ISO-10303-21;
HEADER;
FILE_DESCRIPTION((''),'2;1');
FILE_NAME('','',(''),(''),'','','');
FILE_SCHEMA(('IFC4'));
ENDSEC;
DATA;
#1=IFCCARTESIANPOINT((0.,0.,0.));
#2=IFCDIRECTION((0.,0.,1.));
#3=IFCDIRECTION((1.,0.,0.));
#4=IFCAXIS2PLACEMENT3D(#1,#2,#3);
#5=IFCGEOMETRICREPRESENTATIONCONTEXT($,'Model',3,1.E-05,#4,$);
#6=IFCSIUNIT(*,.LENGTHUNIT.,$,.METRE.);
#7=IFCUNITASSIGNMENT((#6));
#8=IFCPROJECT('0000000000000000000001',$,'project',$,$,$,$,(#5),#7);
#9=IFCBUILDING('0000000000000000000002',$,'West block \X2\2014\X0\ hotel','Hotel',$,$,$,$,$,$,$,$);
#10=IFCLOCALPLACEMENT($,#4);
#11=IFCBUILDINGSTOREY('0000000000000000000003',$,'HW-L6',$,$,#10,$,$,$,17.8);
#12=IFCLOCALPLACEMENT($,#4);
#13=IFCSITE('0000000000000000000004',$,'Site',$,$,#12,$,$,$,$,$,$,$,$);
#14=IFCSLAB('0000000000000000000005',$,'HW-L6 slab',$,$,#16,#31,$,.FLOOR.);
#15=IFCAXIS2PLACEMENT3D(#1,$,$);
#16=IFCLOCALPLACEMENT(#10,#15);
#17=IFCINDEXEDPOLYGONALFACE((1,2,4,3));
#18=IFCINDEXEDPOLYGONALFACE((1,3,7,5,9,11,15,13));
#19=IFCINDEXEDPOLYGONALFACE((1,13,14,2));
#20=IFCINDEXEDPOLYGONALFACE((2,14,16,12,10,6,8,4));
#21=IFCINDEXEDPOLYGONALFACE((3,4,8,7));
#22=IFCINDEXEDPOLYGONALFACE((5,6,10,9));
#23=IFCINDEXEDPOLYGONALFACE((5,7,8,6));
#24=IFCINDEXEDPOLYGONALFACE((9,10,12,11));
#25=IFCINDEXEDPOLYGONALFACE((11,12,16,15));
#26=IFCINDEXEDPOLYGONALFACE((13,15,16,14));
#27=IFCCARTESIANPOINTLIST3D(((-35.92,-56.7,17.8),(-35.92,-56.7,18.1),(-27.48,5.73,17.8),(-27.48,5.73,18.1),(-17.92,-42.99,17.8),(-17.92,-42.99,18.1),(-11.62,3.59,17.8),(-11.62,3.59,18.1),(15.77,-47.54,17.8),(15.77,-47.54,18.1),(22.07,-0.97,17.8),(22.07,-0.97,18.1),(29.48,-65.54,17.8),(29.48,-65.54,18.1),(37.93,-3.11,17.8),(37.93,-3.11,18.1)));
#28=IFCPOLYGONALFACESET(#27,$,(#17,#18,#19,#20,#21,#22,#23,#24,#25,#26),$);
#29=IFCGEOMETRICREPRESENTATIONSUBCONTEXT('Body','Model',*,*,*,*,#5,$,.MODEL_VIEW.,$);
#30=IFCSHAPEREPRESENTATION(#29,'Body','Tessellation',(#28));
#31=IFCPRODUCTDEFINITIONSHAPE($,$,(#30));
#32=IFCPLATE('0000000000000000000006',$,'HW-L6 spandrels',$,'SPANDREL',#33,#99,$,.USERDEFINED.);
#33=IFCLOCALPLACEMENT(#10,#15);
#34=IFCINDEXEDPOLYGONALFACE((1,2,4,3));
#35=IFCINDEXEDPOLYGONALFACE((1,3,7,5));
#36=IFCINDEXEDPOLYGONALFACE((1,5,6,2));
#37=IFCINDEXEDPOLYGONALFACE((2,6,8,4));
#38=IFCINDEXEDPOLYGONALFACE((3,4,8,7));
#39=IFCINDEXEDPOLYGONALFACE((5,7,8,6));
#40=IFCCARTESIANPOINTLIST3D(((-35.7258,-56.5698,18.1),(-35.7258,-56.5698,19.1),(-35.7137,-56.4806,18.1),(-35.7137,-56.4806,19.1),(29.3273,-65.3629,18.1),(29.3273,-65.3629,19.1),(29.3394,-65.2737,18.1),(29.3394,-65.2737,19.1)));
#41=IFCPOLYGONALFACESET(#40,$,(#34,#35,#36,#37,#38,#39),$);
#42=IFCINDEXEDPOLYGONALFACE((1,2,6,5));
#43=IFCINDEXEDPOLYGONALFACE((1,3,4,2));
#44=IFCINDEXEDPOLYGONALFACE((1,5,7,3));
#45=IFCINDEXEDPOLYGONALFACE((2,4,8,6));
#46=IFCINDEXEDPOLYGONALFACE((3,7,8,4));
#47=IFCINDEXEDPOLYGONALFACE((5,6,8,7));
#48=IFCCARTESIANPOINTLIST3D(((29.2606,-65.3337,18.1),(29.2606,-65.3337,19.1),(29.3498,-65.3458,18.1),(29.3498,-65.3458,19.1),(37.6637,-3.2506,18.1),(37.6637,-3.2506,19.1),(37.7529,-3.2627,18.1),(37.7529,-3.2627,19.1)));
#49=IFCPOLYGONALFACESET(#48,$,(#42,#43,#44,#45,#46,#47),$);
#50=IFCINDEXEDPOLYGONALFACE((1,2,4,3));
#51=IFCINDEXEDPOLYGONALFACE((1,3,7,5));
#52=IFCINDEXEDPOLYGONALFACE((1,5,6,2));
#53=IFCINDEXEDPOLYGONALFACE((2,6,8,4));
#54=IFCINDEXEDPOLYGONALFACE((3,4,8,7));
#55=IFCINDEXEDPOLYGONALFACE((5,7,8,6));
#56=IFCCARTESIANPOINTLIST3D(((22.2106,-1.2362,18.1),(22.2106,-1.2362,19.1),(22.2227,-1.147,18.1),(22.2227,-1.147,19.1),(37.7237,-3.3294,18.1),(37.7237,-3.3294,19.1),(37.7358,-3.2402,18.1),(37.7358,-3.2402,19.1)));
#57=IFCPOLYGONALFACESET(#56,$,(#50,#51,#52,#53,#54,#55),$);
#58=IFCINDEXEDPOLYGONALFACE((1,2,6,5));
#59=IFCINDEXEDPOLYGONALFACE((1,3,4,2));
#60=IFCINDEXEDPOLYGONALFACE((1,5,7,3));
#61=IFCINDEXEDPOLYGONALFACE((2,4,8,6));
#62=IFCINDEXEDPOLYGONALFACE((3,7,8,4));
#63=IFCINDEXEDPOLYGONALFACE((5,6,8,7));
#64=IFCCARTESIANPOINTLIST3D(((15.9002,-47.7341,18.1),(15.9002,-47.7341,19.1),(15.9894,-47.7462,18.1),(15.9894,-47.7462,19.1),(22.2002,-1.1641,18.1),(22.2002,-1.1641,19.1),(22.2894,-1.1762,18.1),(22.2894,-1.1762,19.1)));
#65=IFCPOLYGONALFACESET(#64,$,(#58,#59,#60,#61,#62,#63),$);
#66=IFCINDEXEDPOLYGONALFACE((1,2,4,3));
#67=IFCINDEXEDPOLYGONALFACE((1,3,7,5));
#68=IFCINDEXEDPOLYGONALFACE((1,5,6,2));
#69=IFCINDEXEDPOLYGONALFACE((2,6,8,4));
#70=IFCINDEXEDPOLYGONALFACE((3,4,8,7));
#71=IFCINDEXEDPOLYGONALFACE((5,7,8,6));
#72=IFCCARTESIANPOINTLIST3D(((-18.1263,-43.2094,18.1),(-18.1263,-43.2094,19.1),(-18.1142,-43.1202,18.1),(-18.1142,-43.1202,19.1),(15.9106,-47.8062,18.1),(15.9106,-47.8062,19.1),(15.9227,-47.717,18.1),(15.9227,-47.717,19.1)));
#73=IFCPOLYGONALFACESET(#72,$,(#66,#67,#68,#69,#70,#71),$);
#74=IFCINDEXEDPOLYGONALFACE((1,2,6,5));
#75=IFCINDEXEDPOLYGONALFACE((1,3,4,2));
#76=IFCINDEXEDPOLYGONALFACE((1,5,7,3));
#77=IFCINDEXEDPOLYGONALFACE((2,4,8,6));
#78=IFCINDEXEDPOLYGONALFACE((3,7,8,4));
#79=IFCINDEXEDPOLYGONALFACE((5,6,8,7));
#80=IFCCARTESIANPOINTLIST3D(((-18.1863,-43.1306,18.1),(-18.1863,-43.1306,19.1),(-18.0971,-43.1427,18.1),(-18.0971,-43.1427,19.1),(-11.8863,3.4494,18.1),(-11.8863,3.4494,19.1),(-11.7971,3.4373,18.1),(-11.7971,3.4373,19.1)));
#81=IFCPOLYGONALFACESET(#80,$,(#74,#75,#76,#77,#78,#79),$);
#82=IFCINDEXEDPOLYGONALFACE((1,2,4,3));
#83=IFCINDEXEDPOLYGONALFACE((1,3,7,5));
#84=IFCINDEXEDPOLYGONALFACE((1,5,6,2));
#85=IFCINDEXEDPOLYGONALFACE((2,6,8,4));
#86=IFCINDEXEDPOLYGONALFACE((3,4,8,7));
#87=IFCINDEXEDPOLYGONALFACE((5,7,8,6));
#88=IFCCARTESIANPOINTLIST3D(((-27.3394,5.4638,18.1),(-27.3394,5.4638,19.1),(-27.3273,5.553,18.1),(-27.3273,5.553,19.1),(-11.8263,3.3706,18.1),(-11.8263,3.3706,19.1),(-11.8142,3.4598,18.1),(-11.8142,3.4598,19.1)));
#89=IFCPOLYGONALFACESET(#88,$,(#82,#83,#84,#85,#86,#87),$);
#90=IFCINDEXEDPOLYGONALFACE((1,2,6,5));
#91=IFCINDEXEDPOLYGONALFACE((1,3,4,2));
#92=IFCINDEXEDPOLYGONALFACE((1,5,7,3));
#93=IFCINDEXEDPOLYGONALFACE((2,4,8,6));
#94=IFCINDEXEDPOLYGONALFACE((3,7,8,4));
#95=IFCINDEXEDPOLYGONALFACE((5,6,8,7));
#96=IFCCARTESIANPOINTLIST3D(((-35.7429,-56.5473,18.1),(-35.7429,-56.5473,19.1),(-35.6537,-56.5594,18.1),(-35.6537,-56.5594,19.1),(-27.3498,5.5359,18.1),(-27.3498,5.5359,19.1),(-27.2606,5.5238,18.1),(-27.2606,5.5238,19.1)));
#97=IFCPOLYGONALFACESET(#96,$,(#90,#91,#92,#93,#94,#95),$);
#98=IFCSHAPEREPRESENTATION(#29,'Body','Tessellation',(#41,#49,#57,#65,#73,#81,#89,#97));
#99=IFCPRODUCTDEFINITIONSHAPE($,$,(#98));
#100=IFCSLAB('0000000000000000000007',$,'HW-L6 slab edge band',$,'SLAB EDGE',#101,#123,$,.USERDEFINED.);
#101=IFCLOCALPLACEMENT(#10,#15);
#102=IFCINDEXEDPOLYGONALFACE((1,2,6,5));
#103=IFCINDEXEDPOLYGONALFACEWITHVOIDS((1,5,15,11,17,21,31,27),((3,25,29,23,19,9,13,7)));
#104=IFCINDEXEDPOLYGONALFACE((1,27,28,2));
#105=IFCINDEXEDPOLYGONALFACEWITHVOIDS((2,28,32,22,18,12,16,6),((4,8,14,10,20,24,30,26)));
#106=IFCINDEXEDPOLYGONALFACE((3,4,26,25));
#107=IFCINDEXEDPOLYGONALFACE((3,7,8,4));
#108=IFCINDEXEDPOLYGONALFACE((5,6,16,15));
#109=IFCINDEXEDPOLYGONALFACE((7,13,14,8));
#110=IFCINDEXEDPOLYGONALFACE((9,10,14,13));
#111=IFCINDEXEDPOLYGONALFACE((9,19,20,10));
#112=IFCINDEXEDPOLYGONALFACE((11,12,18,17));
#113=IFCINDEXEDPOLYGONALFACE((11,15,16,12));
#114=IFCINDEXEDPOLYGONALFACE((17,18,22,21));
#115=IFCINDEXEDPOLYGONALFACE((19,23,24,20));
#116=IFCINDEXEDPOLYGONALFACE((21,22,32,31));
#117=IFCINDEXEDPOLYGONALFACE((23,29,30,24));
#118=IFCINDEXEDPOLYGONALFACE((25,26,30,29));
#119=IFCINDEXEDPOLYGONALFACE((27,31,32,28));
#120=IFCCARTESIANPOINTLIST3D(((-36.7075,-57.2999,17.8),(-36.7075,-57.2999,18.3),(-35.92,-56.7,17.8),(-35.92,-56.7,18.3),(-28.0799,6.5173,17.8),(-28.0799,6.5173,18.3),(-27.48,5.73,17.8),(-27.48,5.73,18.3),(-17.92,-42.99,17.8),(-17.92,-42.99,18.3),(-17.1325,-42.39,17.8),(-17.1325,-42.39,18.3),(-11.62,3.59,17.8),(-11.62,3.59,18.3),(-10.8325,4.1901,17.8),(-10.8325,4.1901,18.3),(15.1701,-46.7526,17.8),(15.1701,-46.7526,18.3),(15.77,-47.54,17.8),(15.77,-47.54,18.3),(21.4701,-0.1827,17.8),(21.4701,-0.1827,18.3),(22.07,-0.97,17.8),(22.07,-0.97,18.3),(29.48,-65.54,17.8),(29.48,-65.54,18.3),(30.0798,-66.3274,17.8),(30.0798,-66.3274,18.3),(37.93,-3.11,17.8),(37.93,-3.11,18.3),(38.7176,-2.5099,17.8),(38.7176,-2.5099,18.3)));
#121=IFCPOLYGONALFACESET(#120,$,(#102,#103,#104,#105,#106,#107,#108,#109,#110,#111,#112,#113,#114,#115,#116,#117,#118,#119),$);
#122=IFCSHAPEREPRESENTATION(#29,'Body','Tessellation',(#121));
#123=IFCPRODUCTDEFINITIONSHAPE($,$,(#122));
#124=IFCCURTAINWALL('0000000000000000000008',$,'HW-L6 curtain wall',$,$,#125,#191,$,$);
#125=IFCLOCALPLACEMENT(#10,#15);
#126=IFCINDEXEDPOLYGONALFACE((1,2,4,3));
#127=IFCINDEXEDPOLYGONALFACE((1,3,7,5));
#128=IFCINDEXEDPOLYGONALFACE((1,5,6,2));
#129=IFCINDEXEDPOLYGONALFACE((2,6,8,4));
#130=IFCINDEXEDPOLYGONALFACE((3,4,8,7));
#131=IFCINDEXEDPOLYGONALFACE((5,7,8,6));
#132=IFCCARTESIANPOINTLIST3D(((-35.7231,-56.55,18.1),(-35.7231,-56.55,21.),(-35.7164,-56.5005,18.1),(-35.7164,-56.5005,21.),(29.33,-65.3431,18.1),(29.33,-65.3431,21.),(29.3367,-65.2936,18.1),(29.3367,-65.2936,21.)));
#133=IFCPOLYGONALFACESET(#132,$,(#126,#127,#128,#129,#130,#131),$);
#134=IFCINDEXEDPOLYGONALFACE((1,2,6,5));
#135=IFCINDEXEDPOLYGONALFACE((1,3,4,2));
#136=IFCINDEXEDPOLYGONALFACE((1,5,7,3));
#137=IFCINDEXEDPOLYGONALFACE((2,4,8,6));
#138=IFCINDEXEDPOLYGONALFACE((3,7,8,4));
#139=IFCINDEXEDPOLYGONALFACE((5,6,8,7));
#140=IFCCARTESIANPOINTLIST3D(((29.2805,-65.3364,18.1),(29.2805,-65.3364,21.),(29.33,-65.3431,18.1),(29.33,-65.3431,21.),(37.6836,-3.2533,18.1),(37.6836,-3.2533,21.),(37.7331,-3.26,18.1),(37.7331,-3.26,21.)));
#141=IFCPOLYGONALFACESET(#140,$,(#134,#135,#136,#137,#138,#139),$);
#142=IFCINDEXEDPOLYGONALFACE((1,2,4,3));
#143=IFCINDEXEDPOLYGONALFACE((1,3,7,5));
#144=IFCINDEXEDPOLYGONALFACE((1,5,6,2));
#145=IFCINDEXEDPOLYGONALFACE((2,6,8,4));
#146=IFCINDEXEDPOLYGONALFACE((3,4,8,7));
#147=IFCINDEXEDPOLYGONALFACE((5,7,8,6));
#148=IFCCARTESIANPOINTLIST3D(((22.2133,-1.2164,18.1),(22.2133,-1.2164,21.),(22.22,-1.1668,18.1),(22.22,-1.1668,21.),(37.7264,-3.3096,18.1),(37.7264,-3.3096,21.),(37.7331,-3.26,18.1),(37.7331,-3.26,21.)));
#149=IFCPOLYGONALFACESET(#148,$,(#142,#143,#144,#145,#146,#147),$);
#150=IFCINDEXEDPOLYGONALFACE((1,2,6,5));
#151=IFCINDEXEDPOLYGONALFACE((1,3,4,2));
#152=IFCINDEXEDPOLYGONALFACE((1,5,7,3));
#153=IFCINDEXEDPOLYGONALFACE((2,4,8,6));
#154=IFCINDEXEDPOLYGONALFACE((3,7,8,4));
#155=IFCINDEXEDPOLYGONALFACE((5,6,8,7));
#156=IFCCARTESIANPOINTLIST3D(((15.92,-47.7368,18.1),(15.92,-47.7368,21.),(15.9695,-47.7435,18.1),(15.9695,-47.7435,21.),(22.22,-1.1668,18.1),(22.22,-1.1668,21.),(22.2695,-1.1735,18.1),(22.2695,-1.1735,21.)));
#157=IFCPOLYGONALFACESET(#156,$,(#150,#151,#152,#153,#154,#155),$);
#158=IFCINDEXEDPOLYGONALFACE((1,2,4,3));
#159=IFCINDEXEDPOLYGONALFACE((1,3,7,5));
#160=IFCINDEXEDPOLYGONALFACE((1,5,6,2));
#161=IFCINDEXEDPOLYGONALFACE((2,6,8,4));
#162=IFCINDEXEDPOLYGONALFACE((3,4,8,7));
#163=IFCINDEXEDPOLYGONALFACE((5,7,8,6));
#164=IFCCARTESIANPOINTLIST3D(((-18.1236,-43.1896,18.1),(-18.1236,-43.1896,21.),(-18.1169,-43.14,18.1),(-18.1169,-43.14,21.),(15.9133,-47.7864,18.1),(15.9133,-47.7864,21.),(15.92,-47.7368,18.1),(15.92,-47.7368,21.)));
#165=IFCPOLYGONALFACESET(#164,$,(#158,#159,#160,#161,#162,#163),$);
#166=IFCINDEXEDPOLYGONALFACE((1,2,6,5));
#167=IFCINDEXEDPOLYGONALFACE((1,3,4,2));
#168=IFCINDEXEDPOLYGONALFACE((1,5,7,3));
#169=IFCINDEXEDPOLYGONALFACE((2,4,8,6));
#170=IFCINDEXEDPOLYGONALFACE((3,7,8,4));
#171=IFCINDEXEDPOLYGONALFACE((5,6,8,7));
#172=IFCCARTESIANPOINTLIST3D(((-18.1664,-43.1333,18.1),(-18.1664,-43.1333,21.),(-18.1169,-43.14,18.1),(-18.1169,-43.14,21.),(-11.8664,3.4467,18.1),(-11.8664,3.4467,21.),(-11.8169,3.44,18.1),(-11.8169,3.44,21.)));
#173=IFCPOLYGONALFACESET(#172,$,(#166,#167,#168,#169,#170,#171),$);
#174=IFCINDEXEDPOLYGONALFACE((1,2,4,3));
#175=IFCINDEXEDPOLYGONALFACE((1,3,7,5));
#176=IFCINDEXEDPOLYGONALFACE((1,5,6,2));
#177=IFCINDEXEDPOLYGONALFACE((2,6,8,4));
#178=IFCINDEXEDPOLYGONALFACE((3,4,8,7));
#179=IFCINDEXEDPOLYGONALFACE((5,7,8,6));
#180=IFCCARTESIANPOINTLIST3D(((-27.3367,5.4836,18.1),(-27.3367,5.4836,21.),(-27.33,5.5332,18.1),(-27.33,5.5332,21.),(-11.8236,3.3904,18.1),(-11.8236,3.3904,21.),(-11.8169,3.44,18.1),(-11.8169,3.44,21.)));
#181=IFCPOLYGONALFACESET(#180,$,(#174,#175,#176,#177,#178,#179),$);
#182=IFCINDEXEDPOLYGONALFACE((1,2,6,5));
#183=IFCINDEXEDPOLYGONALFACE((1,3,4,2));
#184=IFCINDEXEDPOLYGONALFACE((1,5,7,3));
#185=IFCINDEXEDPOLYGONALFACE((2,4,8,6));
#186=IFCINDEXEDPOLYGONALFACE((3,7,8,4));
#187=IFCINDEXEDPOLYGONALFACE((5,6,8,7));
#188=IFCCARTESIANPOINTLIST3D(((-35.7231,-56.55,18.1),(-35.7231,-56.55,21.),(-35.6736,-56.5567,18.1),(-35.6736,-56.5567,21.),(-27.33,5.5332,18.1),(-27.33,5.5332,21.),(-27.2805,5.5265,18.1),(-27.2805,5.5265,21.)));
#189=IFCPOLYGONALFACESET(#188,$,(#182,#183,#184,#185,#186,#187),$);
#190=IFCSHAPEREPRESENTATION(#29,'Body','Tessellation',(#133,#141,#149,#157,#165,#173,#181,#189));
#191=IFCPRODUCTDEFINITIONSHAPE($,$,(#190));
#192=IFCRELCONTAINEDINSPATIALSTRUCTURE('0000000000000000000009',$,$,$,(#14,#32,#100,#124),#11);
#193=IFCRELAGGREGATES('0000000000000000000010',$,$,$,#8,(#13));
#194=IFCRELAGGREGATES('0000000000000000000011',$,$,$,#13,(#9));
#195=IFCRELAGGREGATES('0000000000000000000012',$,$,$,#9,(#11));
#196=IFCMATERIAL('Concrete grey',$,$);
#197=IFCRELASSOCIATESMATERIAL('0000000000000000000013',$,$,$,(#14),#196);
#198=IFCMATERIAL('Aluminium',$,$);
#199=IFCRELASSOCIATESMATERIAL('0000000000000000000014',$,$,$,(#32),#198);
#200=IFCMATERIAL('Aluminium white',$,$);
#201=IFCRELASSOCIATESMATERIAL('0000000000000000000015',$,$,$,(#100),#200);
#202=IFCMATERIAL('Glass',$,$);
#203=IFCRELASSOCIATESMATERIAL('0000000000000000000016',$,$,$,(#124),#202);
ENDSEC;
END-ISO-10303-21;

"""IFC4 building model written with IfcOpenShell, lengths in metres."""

from ifc_helpers import new_model, si_unit, frame, origin_with_axes, place, context, subcontext, project, spatial, polyline, outline, extrude, material, element, save


model = new_model("IFC4")

# Units and contexts
model_context = context("Model", 3, precision=1e-05, world=origin_with_axes())
body_context = subcontext(model_context, "Body", "Model", "MODEL_VIEW")
ifc_project = project(units=[si_unit("LENGTHUNIT", "METRE")], contexts=[model_context])

# Site, building, storey
site_placement = place(None, origin_with_axes())
site = spatial("IfcSite", under=ifc_project, at=site_placement, Name="Site")
building = spatial("IfcBuilding", under=site, Name="West block — hotel", Description="Hotel")
storey_placement = place(None, origin_with_axes())
storey = spatial("IfcBuildingStorey", under=building, at=storey_placement, Name="HW-L6", Elevation=17.8)

# Shared definitions
ifc_material_1 = material(Name="Aluminium")

# Slab
ifc_material_2 = material(Name="Concrete grey")
slab_1_placement = place(storey_placement, origin_with_axes())
element("IfcSlab", 1, at=slab_1_placement, inside=storey, material=ifc_material_2, Name="HW-L6 slab", PredefinedType="FLOOR", context=body_context, shape_type="SweptSolid", body=[
    extrude(outline(polyline([(-35.92, -56.7), (29.48, -65.54), (37.93, -3.11), (22.07, -0.97), (15.77, -47.54), (-17.92, -42.99), (-11.62, 3.59), (-27.48, 5.73), (-35.92, -56.7)])), frame((0.0, 0.0, 17.8), z_axis=(0.0, 0.0, 1.0), x_axis=(1.0, 0.0, 0.0)), (0.0, 0.0, 1.0), 0.3),
])

# Plate
plate_placement = place(storey_placement, origin_with_axes())
element("IfcPlate", 2, at=plate_placement, inside=storey, material=ifc_material_1, Name="HW-L6 spandrels", ObjectType="SPANDREL", PredefinedType="USERDEFINED", context=body_context, shape_type="SweptSolid", body=[
    extrude(outline(polyline([(-35.7258, -56.5698), (29.3273, -65.3629), (29.3394, -65.2737), (-35.7137, -56.4806), (-35.7258, -56.5698)])), frame((0.0, 0.0, 18.1), z_axis=(0.0, 0.0, 1.0), x_axis=(1.0, 0.0, 0.0)), (0.0, 0.0, 1.0), 1.0),
    extrude(outline(polyline([(29.3498, -65.3458), (37.7529, -3.2627), (37.6637, -3.2506), (29.2606, -65.3337), (29.3498, -65.3458)])), frame((0.0, 0.0, 18.1), z_axis=(0.0, 0.0, 1.0), x_axis=(1.0, 0.0, 0.0)), (0.0, 0.0, 1.0), 1.0),
    extrude(outline(polyline([(37.7358, -3.2402), (22.2227, -1.147), (22.2106, -1.2362), (37.7237, -3.3294), (37.7358, -3.2402)])), frame((0.0, 0.0, 18.1), z_axis=(0.0, 0.0, 1.0), x_axis=(1.0, 0.0, 0.0)), (0.0, 0.0, 1.0), 1.0),
    extrude(outline(polyline([(22.2002, -1.1641), (15.9002, -47.7341), (15.9894, -47.7462), (22.2894, -1.1762), (22.2002, -1.1641)])), frame((0.0, 0.0, 18.1), z_axis=(0.0, 0.0, 1.0), x_axis=(1.0, 0.0, 0.0)), (0.0, 0.0, 1.0), 1.0),
    extrude(outline(polyline([(15.9227, -47.717), (-18.1142, -43.1202), (-18.1263, -43.2094), (15.9106, -47.8062), (15.9227, -47.717)])), frame((0.0, 0.0, 18.1), z_axis=(0.0, 0.0, 1.0), x_axis=(1.0, 0.0, 0.0)), (0.0, 0.0, 1.0), 1.0),
    extrude(outline(polyline([(-18.0971, -43.1427), (-11.7971, 3.4373), (-11.8863, 3.4494), (-18.1863, -43.1306), (-18.0971, -43.1427)])), frame((0.0, 0.0, 18.1), z_axis=(0.0, 0.0, 1.0), x_axis=(1.0, 0.0, 0.0)), (0.0, 0.0, 1.0), 1.0),
    extrude(outline(polyline([(-11.8142, 3.4598), (-27.3273, 5.553), (-27.3394, 5.4638), (-11.8263, 3.3706), (-11.8142, 3.4598)])), frame((0.0, 0.0, 18.1), z_axis=(0.0, 0.0, 1.0), x_axis=(1.0, 0.0, 0.0)), (0.0, 0.0, 1.0), 1.0),
    extrude(outline(polyline([(-27.3498, 5.5359), (-35.7429, -56.5473), (-35.6537, -56.5594), (-27.2606, 5.5238), (-27.3498, 5.5359)])), frame((0.0, 0.0, 18.1), z_axis=(0.0, 0.0, 1.0), x_axis=(1.0, 0.0, 0.0)), (0.0, 0.0, 1.0), 1.0),
])

# Slab
ifc_material_3 = material(Name="Aluminium white")
slab_2_placement = place(storey_placement, origin_with_axes())
element("IfcSlab", 3, at=slab_2_placement, inside=storey, material=ifc_material_3, Name="HW-L6 slab edge band", ObjectType="SLAB EDGE", PredefinedType="USERDEFINED", context=body_context, shape_type="SweptSolid", body=[
    extrude(outline(polyline([(-36.7075, -57.2999), (30.0798, -66.3274), (38.7176, -2.5099), (21.4701, -0.1827), (15.1701, -46.7526), (-17.1325, -42.39), (-10.8325, 4.1901), (-28.0799, 6.5173), (-36.7075, -57.2999)]), holes=[polyline([(-35.92, -56.7), (29.48, -65.54), (37.93, -3.11), (22.07, -0.97), (15.77, -47.54), (-17.92, -42.99), (-11.62, 3.59), (-27.48, 5.73), (-35.92, -56.7)])]), frame((0.0, 0.0, 17.8), z_axis=(0.0, 0.0, 1.0), x_axis=(1.0, 0.0, 0.0)), (0.0, 0.0, 1.0), 0.5),
])

# Curtain wall
ifc_material_4 = material(Name="Glass")
curtain_wall_placement = place(storey_placement, origin_with_axes())
element("IfcCurtainWall", 4, at=curtain_wall_placement, inside=storey, material=ifc_material_4, Name="HW-L6 curtain wall", context=body_context, shape_type="SweptSolid", body=[
    extrude(outline(polyline([(-35.7231, -56.55), (29.33, -65.3431), (29.3367, -65.2936), (-35.7164, -56.5005), (-35.7231, -56.55)])), frame((0.0, 0.0, 18.1), z_axis=(0.0, 0.0, 1.0), x_axis=(1.0, 0.0, 0.0)), (0.0, 0.0, 1.0), 2.9),
    extrude(outline(polyline([(29.33, -65.3431), (37.7331, -3.26), (37.6836, -3.2533), (29.2805, -65.3364), (29.33, -65.3431)])), frame((0.0, 0.0, 18.1), z_axis=(0.0, 0.0, 1.0), x_axis=(1.0, 0.0, 0.0)), (0.0, 0.0, 1.0), 2.9),
    extrude(outline(polyline([(37.7331, -3.26), (22.22, -1.1668), (22.2133, -1.2164), (37.7264, -3.3096), (37.7331, -3.26)])), frame((0.0, 0.0, 18.1), z_axis=(0.0, 0.0, 1.0), x_axis=(1.0, 0.0, 0.0)), (0.0, 0.0, 1.0), 2.9),
    extrude(outline(polyline([(22.22, -1.1668), (15.92, -47.7368), (15.9695, -47.7435), (22.2695, -1.1735), (22.22, -1.1668)])), frame((0.0, 0.0, 18.1), z_axis=(0.0, 0.0, 1.0), x_axis=(1.0, 0.0, 0.0)), (0.0, 0.0, 1.0), 2.9),
    extrude(outline(polyline([(15.92, -47.7368), (-18.1169, -43.14), (-18.1236, -43.1896), (15.9133, -47.7864), (15.92, -47.7368)])), frame((0.0, 0.0, 18.1), z_axis=(0.0, 0.0, 1.0), x_axis=(1.0, 0.0, 0.0)), (0.0, 0.0, 1.0), 2.9),
    extrude(outline(polyline([(-18.1169, -43.14), (-11.8169, 3.44), (-11.8664, 3.4467), (-18.1664, -43.1333), (-18.1169, -43.14)])), frame((0.0, 0.0, 18.1), z_axis=(0.0, 0.0, 1.0), x_axis=(1.0, 0.0, 0.0)), (0.0, 0.0, 1.0), 2.9),
    extrude(outline(polyline([(-11.8169, 3.44), (-27.33, 5.5332), (-27.3367, 5.4836), (-11.8236, 3.3904), (-11.8169, 3.44)])), frame((0.0, 0.0, 18.1), z_axis=(0.0, 0.0, 1.0), x_axis=(1.0, 0.0, 0.0)), (0.0, 0.0, 1.0), 2.9),
    extrude(outline(polyline([(-27.33, 5.5332), (-35.7231, -56.55), (-35.6736, -56.5567), (-27.2805, 5.5265), (-27.33, 5.5332)])), frame((0.0, 0.0, 18.1), z_axis=(0.0, 0.0, 1.0), x_axis=(1.0, 0.0, 0.0)), (0.0, 0.0, 1.0), 2.9),
])

save(model, "model.ifc")
